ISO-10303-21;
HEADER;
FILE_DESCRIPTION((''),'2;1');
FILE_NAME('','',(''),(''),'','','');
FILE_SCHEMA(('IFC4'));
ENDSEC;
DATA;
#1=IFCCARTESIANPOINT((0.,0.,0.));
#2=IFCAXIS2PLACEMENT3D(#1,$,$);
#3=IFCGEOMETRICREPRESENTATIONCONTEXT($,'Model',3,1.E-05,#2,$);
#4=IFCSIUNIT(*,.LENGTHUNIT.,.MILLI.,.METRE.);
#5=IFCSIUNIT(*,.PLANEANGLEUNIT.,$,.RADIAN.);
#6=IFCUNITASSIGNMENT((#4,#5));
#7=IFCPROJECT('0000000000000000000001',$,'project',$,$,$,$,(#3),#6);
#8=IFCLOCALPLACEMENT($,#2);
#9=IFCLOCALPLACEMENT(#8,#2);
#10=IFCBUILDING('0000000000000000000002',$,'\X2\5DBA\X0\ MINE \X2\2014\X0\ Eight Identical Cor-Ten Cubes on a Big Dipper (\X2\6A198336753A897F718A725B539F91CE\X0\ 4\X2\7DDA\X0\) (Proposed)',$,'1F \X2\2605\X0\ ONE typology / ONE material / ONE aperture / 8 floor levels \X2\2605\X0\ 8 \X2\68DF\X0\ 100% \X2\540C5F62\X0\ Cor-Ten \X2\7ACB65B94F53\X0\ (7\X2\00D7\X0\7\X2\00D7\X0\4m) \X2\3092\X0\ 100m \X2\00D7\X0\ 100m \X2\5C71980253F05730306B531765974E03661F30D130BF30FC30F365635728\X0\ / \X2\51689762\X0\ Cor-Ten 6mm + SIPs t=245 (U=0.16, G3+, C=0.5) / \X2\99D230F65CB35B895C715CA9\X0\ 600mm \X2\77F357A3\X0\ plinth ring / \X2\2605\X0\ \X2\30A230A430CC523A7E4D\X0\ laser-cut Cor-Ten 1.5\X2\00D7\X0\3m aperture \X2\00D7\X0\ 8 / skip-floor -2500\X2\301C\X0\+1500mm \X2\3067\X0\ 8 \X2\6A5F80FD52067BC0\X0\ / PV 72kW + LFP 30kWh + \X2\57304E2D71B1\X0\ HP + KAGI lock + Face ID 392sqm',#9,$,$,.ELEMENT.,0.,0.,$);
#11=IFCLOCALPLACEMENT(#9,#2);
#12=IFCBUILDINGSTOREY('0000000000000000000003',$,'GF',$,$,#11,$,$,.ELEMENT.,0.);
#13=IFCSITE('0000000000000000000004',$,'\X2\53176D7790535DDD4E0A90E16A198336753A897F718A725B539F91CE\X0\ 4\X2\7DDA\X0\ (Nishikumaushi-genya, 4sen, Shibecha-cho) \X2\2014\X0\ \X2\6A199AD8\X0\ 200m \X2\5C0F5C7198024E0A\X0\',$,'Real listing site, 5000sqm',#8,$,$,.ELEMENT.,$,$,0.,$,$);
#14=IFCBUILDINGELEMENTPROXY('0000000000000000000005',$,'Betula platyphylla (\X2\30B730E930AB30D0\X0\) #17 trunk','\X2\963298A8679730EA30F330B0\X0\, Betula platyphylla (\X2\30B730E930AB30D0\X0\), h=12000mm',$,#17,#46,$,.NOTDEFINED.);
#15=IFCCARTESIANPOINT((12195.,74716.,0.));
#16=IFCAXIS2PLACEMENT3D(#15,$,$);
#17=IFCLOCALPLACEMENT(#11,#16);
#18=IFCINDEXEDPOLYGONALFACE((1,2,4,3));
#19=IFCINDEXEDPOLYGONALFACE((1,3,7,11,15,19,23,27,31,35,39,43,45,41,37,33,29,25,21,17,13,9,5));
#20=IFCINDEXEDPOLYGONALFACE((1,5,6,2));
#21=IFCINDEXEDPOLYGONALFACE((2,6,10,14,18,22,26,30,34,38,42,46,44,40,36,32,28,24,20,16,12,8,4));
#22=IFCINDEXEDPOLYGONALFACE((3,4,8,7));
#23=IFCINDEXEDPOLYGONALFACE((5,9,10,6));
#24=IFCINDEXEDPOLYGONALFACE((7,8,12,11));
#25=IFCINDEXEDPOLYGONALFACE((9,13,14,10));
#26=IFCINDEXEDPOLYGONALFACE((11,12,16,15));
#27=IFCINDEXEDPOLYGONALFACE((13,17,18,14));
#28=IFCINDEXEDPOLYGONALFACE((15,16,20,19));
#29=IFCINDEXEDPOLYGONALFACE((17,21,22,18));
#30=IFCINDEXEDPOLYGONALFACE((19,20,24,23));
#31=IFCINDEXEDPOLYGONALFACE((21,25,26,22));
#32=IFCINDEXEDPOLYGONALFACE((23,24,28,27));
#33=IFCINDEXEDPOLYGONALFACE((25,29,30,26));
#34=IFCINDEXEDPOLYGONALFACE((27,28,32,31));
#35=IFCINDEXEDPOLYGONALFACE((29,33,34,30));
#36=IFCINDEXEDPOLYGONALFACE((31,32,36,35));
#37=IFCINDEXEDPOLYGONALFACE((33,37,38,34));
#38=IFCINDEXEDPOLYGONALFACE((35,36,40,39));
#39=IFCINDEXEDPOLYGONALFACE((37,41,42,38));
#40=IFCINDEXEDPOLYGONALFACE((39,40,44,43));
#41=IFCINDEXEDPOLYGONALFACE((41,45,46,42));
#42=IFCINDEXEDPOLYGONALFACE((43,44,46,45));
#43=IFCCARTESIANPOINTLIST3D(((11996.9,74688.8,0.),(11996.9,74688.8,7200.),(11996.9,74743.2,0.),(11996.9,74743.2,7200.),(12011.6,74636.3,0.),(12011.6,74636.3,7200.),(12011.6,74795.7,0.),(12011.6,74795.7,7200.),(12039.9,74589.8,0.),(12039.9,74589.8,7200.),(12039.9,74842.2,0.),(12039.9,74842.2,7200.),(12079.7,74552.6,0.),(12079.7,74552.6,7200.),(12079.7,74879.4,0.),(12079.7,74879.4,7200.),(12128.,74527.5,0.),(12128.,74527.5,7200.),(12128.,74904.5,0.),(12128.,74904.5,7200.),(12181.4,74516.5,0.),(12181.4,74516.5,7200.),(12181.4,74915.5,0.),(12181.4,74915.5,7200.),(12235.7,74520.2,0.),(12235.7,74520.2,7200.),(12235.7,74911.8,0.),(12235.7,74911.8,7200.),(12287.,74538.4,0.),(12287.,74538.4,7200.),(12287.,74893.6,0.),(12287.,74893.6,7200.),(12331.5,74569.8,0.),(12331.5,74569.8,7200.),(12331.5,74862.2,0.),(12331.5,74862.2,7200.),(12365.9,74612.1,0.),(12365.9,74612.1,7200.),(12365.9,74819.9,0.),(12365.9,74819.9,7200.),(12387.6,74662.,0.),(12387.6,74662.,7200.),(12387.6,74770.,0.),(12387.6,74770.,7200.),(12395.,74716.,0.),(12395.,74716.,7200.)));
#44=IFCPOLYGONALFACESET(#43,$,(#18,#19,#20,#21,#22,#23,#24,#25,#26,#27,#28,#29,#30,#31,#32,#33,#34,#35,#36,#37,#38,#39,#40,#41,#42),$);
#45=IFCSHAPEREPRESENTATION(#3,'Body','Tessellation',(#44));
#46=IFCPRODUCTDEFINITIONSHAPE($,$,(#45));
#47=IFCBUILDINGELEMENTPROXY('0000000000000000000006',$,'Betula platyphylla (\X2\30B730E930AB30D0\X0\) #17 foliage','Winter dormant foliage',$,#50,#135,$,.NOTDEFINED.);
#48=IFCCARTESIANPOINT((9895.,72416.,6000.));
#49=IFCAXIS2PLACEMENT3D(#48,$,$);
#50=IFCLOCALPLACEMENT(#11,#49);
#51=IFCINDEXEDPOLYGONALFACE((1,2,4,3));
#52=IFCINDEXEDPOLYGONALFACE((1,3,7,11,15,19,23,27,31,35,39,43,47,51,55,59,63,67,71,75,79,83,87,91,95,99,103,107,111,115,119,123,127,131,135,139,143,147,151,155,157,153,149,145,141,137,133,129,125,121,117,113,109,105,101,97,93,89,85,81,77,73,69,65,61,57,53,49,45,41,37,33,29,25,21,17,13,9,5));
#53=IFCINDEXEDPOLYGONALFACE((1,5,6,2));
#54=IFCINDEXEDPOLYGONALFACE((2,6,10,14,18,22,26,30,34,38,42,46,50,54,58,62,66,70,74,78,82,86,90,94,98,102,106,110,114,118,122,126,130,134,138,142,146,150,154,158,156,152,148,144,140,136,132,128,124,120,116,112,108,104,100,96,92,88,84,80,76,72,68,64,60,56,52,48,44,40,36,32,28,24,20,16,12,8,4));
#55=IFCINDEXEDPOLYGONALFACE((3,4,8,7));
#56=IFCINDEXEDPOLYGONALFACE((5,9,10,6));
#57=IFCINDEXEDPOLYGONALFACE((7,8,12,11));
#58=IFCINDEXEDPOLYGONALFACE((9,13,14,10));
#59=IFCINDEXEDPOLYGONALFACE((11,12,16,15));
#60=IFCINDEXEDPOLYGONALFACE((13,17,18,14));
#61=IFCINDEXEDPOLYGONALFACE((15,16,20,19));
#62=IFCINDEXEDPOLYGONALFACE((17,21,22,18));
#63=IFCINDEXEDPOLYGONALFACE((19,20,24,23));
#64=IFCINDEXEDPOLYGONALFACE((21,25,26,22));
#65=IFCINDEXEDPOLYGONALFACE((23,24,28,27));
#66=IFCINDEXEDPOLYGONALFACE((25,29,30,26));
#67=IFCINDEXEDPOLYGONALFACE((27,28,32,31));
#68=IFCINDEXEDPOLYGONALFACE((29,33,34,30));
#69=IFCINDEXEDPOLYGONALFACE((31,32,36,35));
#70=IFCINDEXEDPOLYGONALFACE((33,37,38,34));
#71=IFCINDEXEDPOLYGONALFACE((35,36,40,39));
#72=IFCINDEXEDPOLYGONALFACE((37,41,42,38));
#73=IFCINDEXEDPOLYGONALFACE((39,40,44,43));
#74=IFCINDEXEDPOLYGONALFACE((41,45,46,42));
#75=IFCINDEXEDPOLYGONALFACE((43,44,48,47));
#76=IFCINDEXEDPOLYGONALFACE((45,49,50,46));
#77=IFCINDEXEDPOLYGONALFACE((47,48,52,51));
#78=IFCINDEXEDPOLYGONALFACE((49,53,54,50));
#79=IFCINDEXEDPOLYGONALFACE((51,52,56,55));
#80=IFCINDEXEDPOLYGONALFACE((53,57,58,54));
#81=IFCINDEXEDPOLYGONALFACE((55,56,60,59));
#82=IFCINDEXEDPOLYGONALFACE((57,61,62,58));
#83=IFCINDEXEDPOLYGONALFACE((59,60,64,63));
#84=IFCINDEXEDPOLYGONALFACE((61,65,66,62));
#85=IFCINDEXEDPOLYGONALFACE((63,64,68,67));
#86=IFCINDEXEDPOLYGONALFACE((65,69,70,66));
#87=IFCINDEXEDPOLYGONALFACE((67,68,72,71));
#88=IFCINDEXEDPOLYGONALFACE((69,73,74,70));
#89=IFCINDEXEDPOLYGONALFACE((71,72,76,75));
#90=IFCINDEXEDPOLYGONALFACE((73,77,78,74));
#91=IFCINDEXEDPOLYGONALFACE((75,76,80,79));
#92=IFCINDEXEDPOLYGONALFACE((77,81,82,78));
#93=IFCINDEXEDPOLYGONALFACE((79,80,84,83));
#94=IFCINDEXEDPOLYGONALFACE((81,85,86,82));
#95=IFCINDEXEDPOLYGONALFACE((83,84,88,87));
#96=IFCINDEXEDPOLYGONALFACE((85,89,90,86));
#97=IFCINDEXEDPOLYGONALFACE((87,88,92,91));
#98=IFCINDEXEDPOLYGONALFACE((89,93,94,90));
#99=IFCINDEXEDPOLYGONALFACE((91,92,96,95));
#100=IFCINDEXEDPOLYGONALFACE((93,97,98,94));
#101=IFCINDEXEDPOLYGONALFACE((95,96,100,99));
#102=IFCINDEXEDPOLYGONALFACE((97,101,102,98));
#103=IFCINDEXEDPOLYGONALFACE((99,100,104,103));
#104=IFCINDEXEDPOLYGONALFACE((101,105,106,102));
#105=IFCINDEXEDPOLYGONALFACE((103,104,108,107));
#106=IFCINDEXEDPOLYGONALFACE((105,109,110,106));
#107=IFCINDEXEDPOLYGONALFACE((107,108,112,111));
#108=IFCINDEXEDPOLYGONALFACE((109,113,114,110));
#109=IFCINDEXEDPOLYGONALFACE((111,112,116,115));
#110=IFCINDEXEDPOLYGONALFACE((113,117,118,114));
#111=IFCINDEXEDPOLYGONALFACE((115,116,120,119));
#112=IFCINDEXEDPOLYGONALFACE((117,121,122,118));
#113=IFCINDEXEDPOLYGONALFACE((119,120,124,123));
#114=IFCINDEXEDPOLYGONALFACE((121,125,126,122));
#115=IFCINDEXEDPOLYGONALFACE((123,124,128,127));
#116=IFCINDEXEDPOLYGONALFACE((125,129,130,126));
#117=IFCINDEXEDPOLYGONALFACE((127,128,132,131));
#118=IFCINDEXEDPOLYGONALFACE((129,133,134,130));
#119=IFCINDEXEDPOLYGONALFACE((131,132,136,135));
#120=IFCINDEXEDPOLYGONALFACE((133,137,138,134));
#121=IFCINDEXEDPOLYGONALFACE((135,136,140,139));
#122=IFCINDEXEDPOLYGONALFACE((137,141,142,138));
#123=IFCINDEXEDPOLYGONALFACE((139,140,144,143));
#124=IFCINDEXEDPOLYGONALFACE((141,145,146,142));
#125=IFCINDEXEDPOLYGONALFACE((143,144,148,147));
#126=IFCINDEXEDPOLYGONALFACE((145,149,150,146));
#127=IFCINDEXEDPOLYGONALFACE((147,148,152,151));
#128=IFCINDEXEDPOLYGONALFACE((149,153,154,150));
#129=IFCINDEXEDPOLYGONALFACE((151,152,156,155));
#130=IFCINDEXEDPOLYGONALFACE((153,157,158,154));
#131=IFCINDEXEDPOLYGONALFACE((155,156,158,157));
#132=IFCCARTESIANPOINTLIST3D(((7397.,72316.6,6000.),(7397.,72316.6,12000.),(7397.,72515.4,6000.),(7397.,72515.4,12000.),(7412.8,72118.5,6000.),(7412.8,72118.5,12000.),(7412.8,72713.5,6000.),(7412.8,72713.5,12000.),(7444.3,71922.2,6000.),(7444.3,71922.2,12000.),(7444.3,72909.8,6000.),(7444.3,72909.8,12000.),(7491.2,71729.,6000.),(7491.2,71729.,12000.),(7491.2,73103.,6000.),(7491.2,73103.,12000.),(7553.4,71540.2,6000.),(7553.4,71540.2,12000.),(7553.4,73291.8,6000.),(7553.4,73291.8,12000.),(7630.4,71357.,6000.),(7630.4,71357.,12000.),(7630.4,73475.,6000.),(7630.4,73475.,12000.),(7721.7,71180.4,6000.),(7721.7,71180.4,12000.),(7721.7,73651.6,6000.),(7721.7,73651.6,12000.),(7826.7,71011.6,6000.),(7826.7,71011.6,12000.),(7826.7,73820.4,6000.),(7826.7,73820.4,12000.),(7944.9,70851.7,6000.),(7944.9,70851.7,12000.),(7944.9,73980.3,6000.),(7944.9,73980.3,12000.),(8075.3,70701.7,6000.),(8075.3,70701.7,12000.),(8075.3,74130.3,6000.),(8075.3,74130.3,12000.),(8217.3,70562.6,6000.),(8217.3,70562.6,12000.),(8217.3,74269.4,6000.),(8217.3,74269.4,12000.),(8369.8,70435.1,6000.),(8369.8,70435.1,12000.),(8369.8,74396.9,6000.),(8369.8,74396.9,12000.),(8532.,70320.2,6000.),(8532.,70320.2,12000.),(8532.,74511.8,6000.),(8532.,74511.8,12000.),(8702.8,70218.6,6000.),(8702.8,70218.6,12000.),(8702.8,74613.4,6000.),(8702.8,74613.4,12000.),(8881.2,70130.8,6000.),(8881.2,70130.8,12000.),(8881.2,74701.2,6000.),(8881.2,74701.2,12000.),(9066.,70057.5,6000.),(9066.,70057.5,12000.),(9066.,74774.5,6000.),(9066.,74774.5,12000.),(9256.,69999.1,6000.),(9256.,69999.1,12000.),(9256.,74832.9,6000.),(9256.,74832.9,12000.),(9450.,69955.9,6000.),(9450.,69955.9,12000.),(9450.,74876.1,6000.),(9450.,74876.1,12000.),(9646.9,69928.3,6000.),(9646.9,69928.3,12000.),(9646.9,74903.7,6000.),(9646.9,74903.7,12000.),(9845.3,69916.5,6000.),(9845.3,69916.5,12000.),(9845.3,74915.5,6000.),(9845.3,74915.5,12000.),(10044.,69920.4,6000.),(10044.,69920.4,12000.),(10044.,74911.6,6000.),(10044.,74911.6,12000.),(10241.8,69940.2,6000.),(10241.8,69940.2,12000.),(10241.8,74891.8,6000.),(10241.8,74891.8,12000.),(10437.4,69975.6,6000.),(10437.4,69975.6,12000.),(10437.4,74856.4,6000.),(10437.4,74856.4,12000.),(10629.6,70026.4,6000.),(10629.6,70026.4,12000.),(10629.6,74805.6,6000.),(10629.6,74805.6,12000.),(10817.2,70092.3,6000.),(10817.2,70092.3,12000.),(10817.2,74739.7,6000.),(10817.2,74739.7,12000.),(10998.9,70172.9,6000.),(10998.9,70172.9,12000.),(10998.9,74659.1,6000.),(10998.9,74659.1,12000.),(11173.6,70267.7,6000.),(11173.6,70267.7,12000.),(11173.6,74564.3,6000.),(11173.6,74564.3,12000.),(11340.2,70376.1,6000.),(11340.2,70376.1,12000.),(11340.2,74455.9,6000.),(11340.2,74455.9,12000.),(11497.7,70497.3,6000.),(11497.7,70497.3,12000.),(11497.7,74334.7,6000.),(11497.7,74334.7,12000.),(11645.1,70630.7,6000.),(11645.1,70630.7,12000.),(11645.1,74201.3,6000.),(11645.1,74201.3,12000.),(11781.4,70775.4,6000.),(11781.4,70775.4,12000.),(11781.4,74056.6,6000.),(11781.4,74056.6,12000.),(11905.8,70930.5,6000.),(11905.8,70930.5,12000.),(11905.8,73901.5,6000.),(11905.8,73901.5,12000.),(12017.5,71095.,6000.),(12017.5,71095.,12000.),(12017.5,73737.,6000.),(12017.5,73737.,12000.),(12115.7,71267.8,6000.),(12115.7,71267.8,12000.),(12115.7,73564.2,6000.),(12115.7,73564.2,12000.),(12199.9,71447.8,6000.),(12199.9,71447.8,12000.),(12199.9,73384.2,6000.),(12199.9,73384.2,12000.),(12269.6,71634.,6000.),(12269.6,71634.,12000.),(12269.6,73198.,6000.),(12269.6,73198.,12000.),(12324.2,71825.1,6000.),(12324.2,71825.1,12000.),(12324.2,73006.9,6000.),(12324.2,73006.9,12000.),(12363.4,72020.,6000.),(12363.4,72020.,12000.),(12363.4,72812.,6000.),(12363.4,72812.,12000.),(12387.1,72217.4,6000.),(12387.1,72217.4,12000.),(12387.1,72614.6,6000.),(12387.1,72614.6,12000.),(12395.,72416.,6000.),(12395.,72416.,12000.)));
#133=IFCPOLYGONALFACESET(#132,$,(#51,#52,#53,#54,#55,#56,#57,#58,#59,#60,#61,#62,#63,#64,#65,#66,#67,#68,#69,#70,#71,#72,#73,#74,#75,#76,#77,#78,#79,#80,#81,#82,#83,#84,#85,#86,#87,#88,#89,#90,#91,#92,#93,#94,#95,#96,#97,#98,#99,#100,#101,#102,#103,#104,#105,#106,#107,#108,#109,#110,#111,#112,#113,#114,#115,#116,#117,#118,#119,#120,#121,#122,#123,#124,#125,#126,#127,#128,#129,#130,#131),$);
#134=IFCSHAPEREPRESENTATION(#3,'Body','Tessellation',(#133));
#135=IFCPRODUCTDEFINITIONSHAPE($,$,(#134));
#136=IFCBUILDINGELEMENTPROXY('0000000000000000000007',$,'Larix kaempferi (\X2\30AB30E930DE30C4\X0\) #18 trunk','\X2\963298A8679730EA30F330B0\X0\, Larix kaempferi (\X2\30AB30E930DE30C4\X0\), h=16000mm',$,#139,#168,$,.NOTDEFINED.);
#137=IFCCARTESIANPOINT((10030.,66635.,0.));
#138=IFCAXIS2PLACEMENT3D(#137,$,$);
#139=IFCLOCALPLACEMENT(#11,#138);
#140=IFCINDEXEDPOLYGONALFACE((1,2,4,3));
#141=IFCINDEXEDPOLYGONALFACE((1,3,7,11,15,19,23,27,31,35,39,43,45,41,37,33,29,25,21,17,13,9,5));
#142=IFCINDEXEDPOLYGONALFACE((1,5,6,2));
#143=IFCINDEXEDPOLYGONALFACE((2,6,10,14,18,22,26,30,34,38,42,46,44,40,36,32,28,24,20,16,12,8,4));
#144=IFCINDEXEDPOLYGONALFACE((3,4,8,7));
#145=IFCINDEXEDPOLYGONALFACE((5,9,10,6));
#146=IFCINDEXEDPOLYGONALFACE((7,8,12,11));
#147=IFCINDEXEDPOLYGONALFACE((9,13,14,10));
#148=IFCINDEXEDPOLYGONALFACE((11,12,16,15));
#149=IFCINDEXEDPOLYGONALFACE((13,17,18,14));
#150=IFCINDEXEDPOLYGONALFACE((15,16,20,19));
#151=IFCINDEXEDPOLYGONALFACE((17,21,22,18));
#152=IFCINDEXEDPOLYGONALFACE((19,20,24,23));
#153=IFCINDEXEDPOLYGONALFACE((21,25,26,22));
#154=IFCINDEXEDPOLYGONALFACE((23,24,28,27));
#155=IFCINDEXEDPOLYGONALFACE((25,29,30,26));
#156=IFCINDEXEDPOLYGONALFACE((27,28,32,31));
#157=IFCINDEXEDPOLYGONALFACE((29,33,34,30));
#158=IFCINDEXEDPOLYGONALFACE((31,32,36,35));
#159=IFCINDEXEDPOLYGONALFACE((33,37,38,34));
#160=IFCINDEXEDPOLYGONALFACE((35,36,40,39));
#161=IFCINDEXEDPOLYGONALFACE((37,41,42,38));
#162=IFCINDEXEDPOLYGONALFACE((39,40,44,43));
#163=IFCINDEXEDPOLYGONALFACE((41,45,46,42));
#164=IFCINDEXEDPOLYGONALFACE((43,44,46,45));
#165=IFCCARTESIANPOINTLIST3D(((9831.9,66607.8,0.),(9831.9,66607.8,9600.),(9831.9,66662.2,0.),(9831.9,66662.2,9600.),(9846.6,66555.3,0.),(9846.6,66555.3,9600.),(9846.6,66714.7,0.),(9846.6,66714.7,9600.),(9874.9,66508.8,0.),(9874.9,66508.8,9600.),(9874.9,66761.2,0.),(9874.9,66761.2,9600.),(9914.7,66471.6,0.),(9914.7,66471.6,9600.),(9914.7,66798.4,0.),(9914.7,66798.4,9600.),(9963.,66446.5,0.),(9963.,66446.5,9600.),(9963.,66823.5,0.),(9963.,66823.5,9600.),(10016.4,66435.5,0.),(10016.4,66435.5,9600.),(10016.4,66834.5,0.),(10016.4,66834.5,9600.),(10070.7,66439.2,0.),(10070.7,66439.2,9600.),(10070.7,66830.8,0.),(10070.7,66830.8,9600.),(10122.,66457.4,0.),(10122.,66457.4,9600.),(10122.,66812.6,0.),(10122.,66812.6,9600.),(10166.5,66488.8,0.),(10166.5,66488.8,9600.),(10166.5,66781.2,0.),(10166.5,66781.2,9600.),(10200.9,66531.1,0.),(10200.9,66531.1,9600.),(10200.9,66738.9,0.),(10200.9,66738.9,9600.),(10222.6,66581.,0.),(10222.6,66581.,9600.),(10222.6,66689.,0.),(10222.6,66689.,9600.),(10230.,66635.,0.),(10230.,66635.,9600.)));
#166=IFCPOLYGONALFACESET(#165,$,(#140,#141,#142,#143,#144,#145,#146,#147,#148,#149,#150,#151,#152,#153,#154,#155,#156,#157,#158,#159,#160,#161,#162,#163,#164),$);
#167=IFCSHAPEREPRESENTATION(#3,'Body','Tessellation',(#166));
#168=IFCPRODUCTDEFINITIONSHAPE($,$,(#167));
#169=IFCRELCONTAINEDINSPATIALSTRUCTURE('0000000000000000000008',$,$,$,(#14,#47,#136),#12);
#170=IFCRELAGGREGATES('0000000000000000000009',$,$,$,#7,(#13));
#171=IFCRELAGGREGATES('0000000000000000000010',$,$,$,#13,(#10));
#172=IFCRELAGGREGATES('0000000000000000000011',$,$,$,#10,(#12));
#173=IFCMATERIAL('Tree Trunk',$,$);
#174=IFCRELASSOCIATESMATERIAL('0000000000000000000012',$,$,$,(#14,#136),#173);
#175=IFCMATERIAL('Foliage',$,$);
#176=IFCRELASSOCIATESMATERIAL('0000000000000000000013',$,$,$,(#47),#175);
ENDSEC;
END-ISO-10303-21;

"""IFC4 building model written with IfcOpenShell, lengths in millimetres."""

from ifc_helpers import new_model, si_unit, frame, origin, origin_2d, place, context, project, spatial, circle, extrude, material, element, save


model = new_model("IFC4")

# Units and contexts
model_context = context("Model", 3, precision=1e-05, world=origin())
ifc_project = project(units=[si_unit("LENGTHUNIT", "METRE", prefix="MILLI"), si_unit("PLANEANGLEUNIT", "RADIAN")], contexts=[model_context])

# Site, building, storey
site_placement = place(None, origin())
site = spatial("IfcSite", under=ifc_project, at=site_placement, Name="北海道川上郡標茶町西熊牛原野 4線 (Nishikumaushi-genya, 4sen, Shibecha-cho) — 標高 200m 小山頂上", ObjectType="Real listing site, 5000sqm", CompositionType="ELEMENT", RefElevation=0.0)
building_placement = place(site_placement, origin())
building = spatial("IfcBuilding", under=site, at=building_placement, Name="嶺 MINE — Eight Identical Cor-Ten Cubes on a Big Dipper (標茶町西熊牛原野 4線) (Proposed)", ObjectType="1F ★ ONE typology / ONE material / ONE aperture / 8 floor levels ★ 8 棟 100% 同形 Cor-Ten 立方体 (7×7×4m) を 100m × 100m 山頂台地に北斗七星パターン散在 / 全面 Cor-Ten 6mm + SIPs t=245 (U=0.16, G3+, C=0.5) / 駒ヶ岳安山岩 600mm 石垣 plinth ring / ★ アイヌ刺繍 laser-cut Cor-Ten 1.5×3m aperture × 8 / skip-floor -2500〜+1500mm で 8 機能分節 / PV 72kW + LFP 30kWh + 地中熱 HP + KAGI lock + Face ID 392sqm", CompositionType="ELEMENT", ElevationOfRefHeight=0.0, ElevationOfTerrain=0.0)
storey_placement = place(building_placement, origin())
storey = spatial("IfcBuildingStorey", under=building, at=storey_placement, Name="GF", CompositionType="ELEMENT", Elevation=0.0)

# Building element proxies
ifc_material_1 = material(Name="Tree Trunk")
proxy_1_placement = place(storey_placement, frame((12195.0, 74716.0, 0.0)))
element("IfcBuildingElementProxy", 1, at=proxy_1_placement, inside=storey, material=ifc_material_1, Name="Betula platyphylla (シラカバ) #17 trunk", Description="防風林リング, Betula platyphylla (シラカバ), h=12000mm", PredefinedType="NOTDEFINED", context=model_context, shape_type="SweptSolid", body=[
    extrude(circle(Radius=200.0, at=origin_2d()), frame((12195.0, 74716.0, 0.0)), (0.0, 0.0, 1.0), 7200.0),
])
ifc_material_2 = material(Name="Foliage")
proxy_2_placement = place(storey_placement, frame((9895.0, 72416.0, 6000.0)))
element("IfcBuildingElementProxy", 2, at=proxy_2_placement, inside=storey, material=ifc_material_2, Name="Betula platyphylla (シラカバ) #17 foliage", Description="Winter dormant foliage", PredefinedType="NOTDEFINED", context=model_context, shape_type="SweptSolid", body=[
    extrude(circle(Radius=2500.0, at=origin_2d()), frame((9895.0, 72416.0, 6000.0)), (0.0, 0.0, 1.0), 6000.0),
])
proxy_3_placement = place(storey_placement, frame((10030.0, 66635.0, 0.0)))
element("IfcBuildingElementProxy", 3, at=proxy_3_placement, inside=storey, material=ifc_material_1, Name="Larix kaempferi (カラマツ) #18 trunk", Description="防風林リング, Larix kaempferi (カラマツ), h=16000mm", PredefinedType="NOTDEFINED", context=model_context, shape_type="SweptSolid", body=[
    extrude(circle(Radius=200.0, at=origin_2d()), frame((10030.0, 66635.0, 0.0)), (0.0, 0.0, 1.0), 9600.0),
])

save(model, "model.ifc")
